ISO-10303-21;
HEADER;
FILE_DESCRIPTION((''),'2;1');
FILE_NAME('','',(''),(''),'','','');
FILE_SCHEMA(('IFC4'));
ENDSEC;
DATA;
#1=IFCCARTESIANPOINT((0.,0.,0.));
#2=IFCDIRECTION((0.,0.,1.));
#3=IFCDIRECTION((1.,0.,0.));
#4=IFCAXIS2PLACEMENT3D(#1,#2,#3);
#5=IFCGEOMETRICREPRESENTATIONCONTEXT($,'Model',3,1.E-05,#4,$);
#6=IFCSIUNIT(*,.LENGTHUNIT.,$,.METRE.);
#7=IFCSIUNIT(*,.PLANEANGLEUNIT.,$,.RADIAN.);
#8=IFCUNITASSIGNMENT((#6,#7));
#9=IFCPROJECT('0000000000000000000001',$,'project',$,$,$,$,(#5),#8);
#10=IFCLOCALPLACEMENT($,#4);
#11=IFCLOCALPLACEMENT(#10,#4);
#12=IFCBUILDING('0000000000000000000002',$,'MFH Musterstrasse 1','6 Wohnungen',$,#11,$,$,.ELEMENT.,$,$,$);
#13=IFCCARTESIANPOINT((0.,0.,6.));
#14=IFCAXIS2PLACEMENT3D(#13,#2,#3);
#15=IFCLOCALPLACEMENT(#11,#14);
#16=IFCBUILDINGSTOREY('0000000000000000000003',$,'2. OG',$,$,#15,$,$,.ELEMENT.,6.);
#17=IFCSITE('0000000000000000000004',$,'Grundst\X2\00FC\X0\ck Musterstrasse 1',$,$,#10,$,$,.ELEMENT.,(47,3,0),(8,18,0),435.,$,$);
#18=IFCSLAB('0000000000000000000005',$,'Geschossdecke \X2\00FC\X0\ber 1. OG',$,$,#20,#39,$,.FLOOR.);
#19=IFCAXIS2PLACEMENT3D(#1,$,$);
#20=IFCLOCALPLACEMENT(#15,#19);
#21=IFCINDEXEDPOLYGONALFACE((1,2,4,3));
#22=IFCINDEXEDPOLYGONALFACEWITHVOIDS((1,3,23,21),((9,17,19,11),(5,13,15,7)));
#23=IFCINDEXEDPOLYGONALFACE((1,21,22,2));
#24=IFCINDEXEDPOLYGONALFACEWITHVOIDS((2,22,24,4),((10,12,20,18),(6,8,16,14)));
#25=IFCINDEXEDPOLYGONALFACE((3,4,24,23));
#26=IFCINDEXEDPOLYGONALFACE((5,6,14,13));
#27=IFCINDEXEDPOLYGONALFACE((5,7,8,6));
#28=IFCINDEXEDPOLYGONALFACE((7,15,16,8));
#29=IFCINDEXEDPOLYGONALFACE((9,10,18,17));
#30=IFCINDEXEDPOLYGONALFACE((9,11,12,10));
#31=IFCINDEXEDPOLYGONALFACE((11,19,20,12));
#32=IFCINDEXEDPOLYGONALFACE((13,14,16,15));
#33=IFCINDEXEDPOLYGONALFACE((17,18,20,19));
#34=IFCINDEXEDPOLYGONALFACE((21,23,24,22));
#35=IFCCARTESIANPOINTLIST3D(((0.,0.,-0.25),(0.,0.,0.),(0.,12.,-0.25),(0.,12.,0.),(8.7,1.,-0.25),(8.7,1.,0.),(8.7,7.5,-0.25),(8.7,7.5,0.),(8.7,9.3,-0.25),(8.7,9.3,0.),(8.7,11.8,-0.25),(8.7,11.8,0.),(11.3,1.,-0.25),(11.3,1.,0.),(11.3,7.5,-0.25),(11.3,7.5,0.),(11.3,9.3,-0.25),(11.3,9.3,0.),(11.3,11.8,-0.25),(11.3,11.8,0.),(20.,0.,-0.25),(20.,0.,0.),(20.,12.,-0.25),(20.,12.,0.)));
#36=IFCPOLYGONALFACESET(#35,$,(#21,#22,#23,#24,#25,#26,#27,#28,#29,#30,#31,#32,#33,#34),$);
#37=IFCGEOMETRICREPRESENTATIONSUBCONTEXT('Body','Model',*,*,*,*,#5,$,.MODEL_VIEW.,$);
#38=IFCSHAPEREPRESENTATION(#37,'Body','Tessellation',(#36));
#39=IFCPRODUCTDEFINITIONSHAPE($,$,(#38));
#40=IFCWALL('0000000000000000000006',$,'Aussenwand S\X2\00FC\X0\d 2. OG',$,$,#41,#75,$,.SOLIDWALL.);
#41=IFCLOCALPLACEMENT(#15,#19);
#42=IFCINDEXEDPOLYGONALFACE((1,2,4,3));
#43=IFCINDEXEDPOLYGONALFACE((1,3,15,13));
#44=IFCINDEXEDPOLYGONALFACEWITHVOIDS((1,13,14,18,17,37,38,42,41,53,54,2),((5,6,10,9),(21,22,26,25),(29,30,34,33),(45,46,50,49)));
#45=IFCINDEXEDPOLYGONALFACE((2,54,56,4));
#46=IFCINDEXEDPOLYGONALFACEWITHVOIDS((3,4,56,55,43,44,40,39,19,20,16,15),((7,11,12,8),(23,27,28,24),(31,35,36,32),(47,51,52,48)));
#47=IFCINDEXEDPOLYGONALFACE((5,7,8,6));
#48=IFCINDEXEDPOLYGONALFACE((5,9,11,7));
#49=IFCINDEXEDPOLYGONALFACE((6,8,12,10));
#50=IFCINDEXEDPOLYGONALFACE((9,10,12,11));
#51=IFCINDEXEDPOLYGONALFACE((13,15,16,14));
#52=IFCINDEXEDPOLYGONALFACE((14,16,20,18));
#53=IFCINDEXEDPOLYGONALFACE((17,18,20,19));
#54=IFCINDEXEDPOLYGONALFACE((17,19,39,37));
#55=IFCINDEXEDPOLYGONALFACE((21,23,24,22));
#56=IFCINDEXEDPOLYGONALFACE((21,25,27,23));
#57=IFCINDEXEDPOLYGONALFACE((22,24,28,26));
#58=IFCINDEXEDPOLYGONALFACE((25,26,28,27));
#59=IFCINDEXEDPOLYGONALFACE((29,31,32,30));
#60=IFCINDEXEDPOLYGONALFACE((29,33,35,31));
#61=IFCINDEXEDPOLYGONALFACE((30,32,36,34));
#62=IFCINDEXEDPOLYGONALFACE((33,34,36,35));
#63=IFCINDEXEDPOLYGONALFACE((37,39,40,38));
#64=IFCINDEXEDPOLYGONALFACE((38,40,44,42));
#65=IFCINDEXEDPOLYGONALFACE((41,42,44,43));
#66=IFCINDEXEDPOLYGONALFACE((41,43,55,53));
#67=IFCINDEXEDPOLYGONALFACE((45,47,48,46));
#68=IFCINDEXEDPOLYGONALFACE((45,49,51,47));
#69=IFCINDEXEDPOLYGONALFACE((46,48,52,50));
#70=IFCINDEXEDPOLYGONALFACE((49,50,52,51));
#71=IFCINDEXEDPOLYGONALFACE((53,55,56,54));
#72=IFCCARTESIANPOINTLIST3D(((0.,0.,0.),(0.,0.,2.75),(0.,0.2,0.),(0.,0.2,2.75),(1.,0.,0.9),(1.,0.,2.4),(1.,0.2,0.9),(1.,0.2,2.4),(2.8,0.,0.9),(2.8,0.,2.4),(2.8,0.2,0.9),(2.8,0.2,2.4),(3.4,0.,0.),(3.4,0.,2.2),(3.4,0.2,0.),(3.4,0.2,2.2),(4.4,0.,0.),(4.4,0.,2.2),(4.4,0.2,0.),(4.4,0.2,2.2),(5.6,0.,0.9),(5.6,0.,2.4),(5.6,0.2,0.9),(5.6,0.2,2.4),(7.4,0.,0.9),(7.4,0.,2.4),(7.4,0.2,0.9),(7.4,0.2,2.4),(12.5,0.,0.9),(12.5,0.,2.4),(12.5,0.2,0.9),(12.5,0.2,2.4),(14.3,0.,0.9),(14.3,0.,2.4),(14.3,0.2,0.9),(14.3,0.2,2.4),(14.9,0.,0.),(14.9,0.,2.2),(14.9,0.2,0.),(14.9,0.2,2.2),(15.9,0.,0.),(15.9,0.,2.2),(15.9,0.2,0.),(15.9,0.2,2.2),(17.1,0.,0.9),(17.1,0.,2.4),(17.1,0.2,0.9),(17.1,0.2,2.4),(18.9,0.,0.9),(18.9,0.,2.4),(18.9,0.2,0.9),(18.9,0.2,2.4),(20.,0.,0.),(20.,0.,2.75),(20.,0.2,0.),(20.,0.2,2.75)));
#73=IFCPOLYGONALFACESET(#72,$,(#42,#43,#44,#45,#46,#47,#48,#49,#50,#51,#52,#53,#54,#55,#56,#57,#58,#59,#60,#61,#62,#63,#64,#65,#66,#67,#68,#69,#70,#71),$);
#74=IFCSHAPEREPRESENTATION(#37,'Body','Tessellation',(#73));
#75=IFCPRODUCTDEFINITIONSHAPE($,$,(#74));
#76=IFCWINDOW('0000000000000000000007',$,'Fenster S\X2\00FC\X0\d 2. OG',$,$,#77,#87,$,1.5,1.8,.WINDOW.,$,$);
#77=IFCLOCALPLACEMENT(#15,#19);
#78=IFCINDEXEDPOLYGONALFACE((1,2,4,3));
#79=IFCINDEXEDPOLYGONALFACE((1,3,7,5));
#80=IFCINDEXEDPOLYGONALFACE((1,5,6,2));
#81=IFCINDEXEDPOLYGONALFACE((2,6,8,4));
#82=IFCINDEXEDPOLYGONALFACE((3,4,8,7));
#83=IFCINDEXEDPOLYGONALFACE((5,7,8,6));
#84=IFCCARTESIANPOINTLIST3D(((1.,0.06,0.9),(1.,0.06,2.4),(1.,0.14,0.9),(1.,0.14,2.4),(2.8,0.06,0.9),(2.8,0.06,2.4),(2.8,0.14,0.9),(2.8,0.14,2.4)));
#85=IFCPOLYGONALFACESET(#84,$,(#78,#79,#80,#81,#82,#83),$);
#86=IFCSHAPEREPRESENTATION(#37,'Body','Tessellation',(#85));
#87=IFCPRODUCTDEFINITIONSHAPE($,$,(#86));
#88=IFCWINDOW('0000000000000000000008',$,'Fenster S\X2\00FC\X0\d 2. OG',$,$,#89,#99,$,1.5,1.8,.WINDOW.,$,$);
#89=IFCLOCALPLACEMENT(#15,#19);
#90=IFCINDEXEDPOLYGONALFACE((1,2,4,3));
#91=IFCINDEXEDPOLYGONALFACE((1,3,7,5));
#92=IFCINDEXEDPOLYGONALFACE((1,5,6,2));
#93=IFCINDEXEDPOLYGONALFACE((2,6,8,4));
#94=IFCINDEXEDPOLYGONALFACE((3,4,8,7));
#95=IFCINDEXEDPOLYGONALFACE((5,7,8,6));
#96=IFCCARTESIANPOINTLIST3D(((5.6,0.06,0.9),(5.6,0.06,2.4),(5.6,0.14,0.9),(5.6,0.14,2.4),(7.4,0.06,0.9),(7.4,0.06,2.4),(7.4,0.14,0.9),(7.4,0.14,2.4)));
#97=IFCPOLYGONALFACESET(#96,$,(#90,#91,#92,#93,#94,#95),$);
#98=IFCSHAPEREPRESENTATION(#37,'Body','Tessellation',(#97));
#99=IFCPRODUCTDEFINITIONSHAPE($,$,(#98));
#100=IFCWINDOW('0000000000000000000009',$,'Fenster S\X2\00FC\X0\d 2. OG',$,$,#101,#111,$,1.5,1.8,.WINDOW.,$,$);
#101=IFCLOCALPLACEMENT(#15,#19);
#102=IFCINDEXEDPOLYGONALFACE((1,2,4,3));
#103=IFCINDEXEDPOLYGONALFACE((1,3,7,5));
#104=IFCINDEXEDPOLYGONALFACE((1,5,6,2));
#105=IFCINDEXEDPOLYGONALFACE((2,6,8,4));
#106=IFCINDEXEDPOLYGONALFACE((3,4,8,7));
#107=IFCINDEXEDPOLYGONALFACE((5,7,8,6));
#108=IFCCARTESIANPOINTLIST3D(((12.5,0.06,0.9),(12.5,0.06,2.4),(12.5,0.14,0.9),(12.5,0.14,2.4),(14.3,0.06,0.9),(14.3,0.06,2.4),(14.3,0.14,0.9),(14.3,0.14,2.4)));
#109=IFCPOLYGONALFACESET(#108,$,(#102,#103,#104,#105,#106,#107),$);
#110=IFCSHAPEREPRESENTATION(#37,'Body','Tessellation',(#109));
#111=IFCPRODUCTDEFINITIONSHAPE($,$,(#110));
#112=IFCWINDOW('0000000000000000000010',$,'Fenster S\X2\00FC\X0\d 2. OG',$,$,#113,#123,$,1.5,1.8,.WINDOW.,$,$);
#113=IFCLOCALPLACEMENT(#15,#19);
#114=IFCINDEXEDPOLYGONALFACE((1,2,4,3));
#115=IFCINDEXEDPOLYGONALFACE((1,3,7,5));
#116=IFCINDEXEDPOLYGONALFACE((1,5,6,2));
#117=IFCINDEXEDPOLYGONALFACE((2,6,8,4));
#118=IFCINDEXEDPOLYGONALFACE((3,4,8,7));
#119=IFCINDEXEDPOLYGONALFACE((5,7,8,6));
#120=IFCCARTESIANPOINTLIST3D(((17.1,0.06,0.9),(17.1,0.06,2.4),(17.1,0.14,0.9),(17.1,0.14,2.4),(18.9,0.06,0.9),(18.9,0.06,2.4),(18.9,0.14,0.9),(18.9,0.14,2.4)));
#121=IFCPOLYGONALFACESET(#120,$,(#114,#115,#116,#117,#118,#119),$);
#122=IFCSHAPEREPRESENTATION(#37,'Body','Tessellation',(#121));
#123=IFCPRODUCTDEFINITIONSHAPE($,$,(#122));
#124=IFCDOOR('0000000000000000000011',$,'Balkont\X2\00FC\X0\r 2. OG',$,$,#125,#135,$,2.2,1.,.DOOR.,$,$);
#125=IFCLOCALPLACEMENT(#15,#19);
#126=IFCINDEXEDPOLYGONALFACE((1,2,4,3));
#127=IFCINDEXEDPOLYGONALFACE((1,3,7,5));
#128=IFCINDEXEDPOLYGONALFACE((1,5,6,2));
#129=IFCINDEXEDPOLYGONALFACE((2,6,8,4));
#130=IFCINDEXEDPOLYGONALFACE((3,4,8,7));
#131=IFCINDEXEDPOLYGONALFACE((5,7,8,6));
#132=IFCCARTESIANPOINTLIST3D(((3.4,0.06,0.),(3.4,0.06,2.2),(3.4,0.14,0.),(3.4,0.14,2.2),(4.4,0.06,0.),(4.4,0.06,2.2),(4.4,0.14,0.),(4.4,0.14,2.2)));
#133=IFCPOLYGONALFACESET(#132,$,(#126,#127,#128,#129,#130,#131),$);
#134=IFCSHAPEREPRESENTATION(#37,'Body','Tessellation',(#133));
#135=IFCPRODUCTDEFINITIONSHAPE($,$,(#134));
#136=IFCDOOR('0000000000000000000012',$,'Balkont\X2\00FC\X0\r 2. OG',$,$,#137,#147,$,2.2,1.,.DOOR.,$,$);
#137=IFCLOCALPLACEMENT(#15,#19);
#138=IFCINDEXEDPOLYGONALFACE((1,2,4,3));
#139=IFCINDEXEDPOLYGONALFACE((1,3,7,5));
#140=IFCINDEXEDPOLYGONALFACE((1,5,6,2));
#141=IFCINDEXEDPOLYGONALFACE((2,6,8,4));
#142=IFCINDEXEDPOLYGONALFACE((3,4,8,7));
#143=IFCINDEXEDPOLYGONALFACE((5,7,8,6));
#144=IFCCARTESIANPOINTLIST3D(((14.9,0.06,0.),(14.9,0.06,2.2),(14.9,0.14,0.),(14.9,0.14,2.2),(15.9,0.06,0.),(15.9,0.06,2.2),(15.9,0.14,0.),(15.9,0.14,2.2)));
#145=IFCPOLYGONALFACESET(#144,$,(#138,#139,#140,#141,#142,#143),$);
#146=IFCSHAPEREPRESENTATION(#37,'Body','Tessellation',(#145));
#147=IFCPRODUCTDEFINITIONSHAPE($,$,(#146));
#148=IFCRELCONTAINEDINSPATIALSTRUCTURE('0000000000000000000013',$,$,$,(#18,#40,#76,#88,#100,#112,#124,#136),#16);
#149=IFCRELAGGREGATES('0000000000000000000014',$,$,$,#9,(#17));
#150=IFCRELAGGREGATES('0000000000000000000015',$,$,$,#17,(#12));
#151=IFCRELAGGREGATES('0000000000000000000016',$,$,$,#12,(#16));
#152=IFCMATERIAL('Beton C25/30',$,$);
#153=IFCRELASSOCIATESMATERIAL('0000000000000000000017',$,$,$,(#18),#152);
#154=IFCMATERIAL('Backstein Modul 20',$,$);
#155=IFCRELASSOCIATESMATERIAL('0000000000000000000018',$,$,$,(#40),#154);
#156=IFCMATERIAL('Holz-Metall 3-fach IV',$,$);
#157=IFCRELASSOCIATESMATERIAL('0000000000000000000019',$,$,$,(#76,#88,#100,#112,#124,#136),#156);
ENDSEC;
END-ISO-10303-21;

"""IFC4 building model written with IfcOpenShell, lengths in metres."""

from ifc_helpers import new_model, si_unit, frame, frame_2d, origin_with_axes, place, context, subcontext, project, spatial, rectangle, extrude, material, element, fill, save


model = new_model("IFC4")

# Units and contexts
model_context = context("Model", 3, precision=1e-05, world=origin_with_axes())
body_context = subcontext(model_context, "Body", "Model", "MODEL_VIEW")
ifc_project = project(units=[si_unit("LENGTHUNIT", "METRE"), si_unit("PLANEANGLEUNIT", "RADIAN")], contexts=[model_context])

# Site, building, storey
site_placement = place(None, origin_with_axes())
site = spatial("IfcSite", under=ifc_project, at=site_placement, Name="Grundstück Musterstrasse 1", CompositionType="ELEMENT", RefLatitude=(47, 3, 0), RefLongitude=(8, 18, 0), RefElevation=435.0)
building_placement = place(site_placement, origin_with_axes())
building = spatial("IfcBuilding", under=site, at=building_placement, Name="MFH Musterstrasse 1", Description="6 Wohnungen", CompositionType="ELEMENT")
storey_placement = place(building_placement, frame((0.0, 0.0, 6.0), z_axis=(0.0, 0.0, 1.0), x_axis=(1.0, 0.0, 0.0)))
storey = spatial("IfcBuildingStorey", under=building, at=storey_placement, Name="2. OG", CompositionType="ELEMENT", Elevation=6.0)

# Slab, openings
ifc_material_1 = material(Name="Beton C25/30")
slab_placement = place(storey_placement, origin_with_axes())
slab = element("IfcSlab", 1, at=slab_placement, inside=storey, material=ifc_material_1, Name="Geschossdecke über 1. OG", PredefinedType="FLOOR", context=body_context, shape_type="SweptSolid", body=[
    extrude(rectangle(XDim=20.0, YDim=12.0, at=frame_2d((10.0, 6.0), x_axis=(1.0, 0.0))), frame((0.0, 0.0, -0.25), z_axis=(0.0, 0.0, 1.0), x_axis=(1.0, 0.0, 0.0)), (0.0, 0.0, 1.0), 0.25),
])
opening_1_placement = place(storey_placement, origin_with_axes())
element("IfcOpeningElement", 2, at=opening_1_placement, cuts=slab, PredefinedType="OPENING", context=body_context, shape_type="SweptSolid", body=[
    extrude(rectangle(XDim=2.6, YDim=6.5, at=frame_2d((1.3, 3.25), x_axis=(1.0, 0.0))), frame((8.7, 1.0, -0.26), z_axis=(0.0, 0.0, 1.0), x_axis=(1.0, 0.0, 0.0)), (0.0, 0.0, 1.0), 0.27),
])
opening_2_placement = place(storey_placement, origin_with_axes())
element("IfcOpeningElement", 3, at=opening_2_placement, cuts=slab, PredefinedType="OPENING", context=body_context, shape_type="SweptSolid", body=[
    extrude(rectangle(XDim=2.6, YDim=2.5, at=frame_2d((1.3, 1.25), x_axis=(1.0, 0.0))), frame((8.7, 9.3, -0.26), z_axis=(0.0, 0.0, 1.0), x_axis=(1.0, 0.0, 0.0)), (0.0, 0.0, 1.0), 0.27),
])

# Wall, openings, windows, doors
ifc_material_2 = material(Name="Backstein Modul 20")
wall_1_placement = place(storey_placement, origin_with_axes())
wall_1 = element("IfcWall", 4, at=wall_1_placement, inside=storey, material=ifc_material_2, Name="Aussenwand Süd 2. OG", PredefinedType="SOLIDWALL", context=body_context, shape_type="SweptSolid", body=[
    extrude(rectangle(XDim=20.0, YDim=0.2, at=frame_2d((10.0, 0.1), x_axis=(1.0, 0.0))), origin_with_axes(), (0.0, 0.0, 1.0), 2.75),
])
opening_3_placement = place(storey_placement, origin_with_axes())
element("IfcOpeningElement", 5, at=opening_3_placement, cuts=wall_1, PredefinedType="OPENING", context=body_context, shape_type="SweptSolid", body=[
    extrude(rectangle(XDim=1.8, YDim=0.3, at=frame_2d((0.9, 0.15), x_axis=(1.0, 0.0))), frame((1.0, -0.05, 0.9), z_axis=(0.0, 0.0, 1.0), x_axis=(1.0, 0.0, 0.0)), (0.0, 0.0, 1.0), 1.5),
])
opening_4_placement = place(storey_placement, origin_with_axes())
element("IfcOpeningElement", 6, at=opening_4_placement, cuts=wall_1, PredefinedType="OPENING", context=body_context, shape_type="SweptSolid", body=[
    extrude(rectangle(XDim=1.8, YDim=0.3, at=frame_2d((0.9, 0.15), x_axis=(1.0, 0.0))), frame((5.6, -0.05, 0.9), z_axis=(0.0, 0.0, 1.0), x_axis=(1.0, 0.0, 0.0)), (0.0, 0.0, 1.0), 1.5),
])
opening_5_placement = place(storey_placement, origin_with_axes())
element("IfcOpeningElement", 7, at=opening_5_placement, cuts=wall_1, PredefinedType="OPENING", context=body_context, shape_type="SweptSolid", body=[
    extrude(rectangle(XDim=1.8, YDim=0.3, at=frame_2d((0.9, 0.15), x_axis=(1.0, 0.0))), frame((12.5, -0.05, 0.9), z_axis=(0.0, 0.0, 1.0), x_axis=(1.0, 0.0, 0.0)), (0.0, 0.0, 1.0), 1.5),
])
opening_6_placement = place(storey_placement, origin_with_axes())
element("IfcOpeningElement", 8, at=opening_6_placement, cuts=wall_1, PredefinedType="OPENING", context=body_context, shape_type="SweptSolid", body=[
    extrude(rectangle(XDim=1.8, YDim=0.3, at=frame_2d((0.9, 0.15), x_axis=(1.0, 0.0))), frame((17.1, -0.05, 0.9), z_axis=(0.0, 0.0, 1.0), x_axis=(1.0, 0.0, 0.0)), (0.0, 0.0, 1.0), 1.5),
])
opening_7_placement = place(storey_placement, origin_with_axes())
element("IfcOpeningElement", 9, at=opening_7_placement, cuts=wall_1, PredefinedType="OPENING", context=body_context, shape_type="SweptSolid", body=[
    extrude(rectangle(XDim=1.0, YDim=0.3, at=frame_2d((0.5, 0.15), x_axis=(1.0, 0.0))), frame((3.4, -0.05, 0.0), z_axis=(0.0, 0.0, 1.0), x_axis=(1.0, 0.0, 0.0)), (0.0, 0.0, 1.0), 2.2),
])
opening_8_placement = place(storey_placement, origin_with_axes())
element("IfcOpeningElement", 10, at=opening_8_placement, cuts=wall_1, PredefinedType="OPENING", context=body_context, shape_type="SweptSolid", body=[
    extrude(rectangle(XDim=1.0, YDim=0.3, at=frame_2d((0.5, 0.15), x_axis=(1.0, 0.0))), frame((14.9, -0.05, 0.0), z_axis=(0.0, 0.0, 1.0), x_axis=(1.0, 0.0, 0.0)), (0.0, 0.0, 1.0), 2.2),
])
opening_9_placement = place(storey_placement, origin_with_axes())
opening_9 = element("IfcOpeningElement", 11, at=opening_9_placement, cuts=wall_1, PredefinedType="OPENING", context=body_context, shape_type="SweptSolid", body=[
    extrude(rectangle(XDim=1.8, YDim=0.22, at=frame_2d((0.9, 0.11), x_axis=(1.0, 0.0))), frame((1.0, -0.01, 0.9), z_axis=(0.0, 0.0, 1.0), x_axis=(1.0, 0.0, 0.0)), (0.0, 0.0, 1.0), 1.5),
])
opening_10_placement = place(storey_placement, origin_with_axes())
opening_10 = element("IfcOpeningElement", 12, at=opening_10_placement, cuts=wall_1, PredefinedType="OPENING", context=body_context, shape_type="SweptSolid", body=[
    extrude(rectangle(XDim=1.8, YDim=0.22, at=frame_2d((0.9, 0.11), x_axis=(1.0, 0.0))), frame((5.6, -0.01, 0.9), z_axis=(0.0, 0.0, 1.0), x_axis=(1.0, 0.0, 0.0)), (0.0, 0.0, 1.0), 1.5),
])
opening_11_placement = place(storey_placement, origin_with_axes())
opening_11 = element("IfcOpeningElement", 13, at=opening_11_placement, cuts=wall_1, PredefinedType="OPENING", context=body_context, shape_type="SweptSolid", body=[
    extrude(rectangle(XDim=1.8, YDim=0.22, at=frame_2d((0.9, 0.11), x_axis=(1.0, 0.0))), frame((12.5, -0.01, 0.9), z_axis=(0.0, 0.0, 1.0), x_axis=(1.0, 0.0, 0.0)), (0.0, 0.0, 1.0), 1.5),
])
opening_12_placement = place(storey_placement, origin_with_axes())
opening_12 = element("IfcOpeningElement", 14, at=opening_12_placement, cuts=wall_1, PredefinedType="OPENING", context=body_context, shape_type="SweptSolid", body=[
    extrude(rectangle(XDim=1.8, YDim=0.22, at=frame_2d((0.9, 0.11), x_axis=(1.0, 0.0))), frame((17.1, -0.01, 0.9), z_axis=(0.0, 0.0, 1.0), x_axis=(1.0, 0.0, 0.0)), (0.0, 0.0, 1.0), 1.5),
])
opening_13_placement = place(storey_placement, origin_with_axes())
opening_13 = element("IfcOpeningElement", 15, at=opening_13_placement, cuts=wall_1, PredefinedType="OPENING", context=body_context, shape_type="SweptSolid", body=[
    extrude(rectangle(XDim=1.0, YDim=0.22, at=frame_2d((0.5, 0.11), x_axis=(1.0, 0.0))), frame((3.4, -0.01, 0.0), z_axis=(0.0, 0.0, 1.0), x_axis=(1.0, 0.0, 0.0)), (0.0, 0.0, 1.0), 2.2),
])
opening_14_placement = place(storey_placement, origin_with_axes())
opening_14 = element("IfcOpeningElement", 16, at=opening_14_placement, cuts=wall_1, PredefinedType="OPENING", context=body_context, shape_type="SweptSolid", body=[
    extrude(rectangle(XDim=1.0, YDim=0.22, at=frame_2d((0.5, 0.11), x_axis=(1.0, 0.0))), frame((14.9, -0.01, 0.0), z_axis=(0.0, 0.0, 1.0), x_axis=(1.0, 0.0, 0.0)), (0.0, 0.0, 1.0), 2.2),
])
ifc_material_3 = material(Name="Holz-Metall 3-fach IV")
window_1_placement = place(storey_placement, origin_with_axes())
window_1 = element("IfcWindow", 17, at=window_1_placement, inside=storey, material=ifc_material_3, Name="Fenster Süd 2. OG", OverallHeight=1.5, OverallWidth=1.8, PredefinedType="WINDOW", context=body_context, shape_type="SweptSolid", body=[
    extrude(rectangle(XDim=1.8, YDim=0.08, at=frame_2d((0.9, 0.04), x_axis=(1.0, 0.0))), frame((1.0, 0.06, 0.9), z_axis=(0.0, 0.0, 1.0), x_axis=(1.0, 0.0, 0.0)), (0.0, 0.0, 1.0), 1.5),
])
fill(opening_9, window_1)
window_2_placement = place(storey_placement, origin_with_axes())
window_2 = element("IfcWindow", 18, at=window_2_placement, inside=storey, material=ifc_material_3, Name="Fenster Süd 2. OG", OverallHeight=1.5, OverallWidth=1.8, PredefinedType="WINDOW", context=body_context, shape_type="SweptSolid", body=[
    extrude(rectangle(XDim=1.8, YDim=0.08, at=frame_2d((0.9, 0.04), x_axis=(1.0, 0.0))), frame((5.6, 0.06, 0.9), z_axis=(0.0, 0.0, 1.0), x_axis=(1.0, 0.0, 0.0)), (0.0, 0.0, 1.0), 1.5),
])
fill(opening_10, window_2)
window_3_placement = place(storey_placement, origin_with_axes())
window_3 = element("IfcWindow", 19, at=window_3_placement, inside=storey, material=ifc_material_3, Name="Fenster Süd 2. OG", OverallHeight=1.5, OverallWidth=1.8, PredefinedType="WINDOW", context=body_context, shape_type="SweptSolid", body=[
    extrude(rectangle(XDim=1.8, YDim=0.08, at=frame_2d((0.9, 0.04), x_axis=(1.0, 0.0))), frame((12.5, 0.06, 0.9), z_axis=(0.0, 0.0, 1.0), x_axis=(1.0, 0.0, 0.0)), (0.0, 0.0, 1.0), 1.5),
])
fill(opening_11, window_3)
window_4_placement = place(storey_placement, origin_with_axes())
window_4 = element("IfcWindow", 20, at=window_4_placement, inside=storey, material=ifc_material_3, Name="Fenster Süd 2. OG", OverallHeight=1.5, OverallWidth=1.8, PredefinedType="WINDOW", context=body_context, shape_type="SweptSolid", body=[
    extrude(rectangle(XDim=1.8, YDim=0.08, at=frame_2d((0.9, 0.04), x_axis=(1.0, 0.0))), frame((17.1, 0.06, 0.9), z_axis=(0.0, 0.0, 1.0), x_axis=(1.0, 0.0, 0.0)), (0.0, 0.0, 1.0), 1.5),
])
fill(opening_12, window_4)
door_1_placement = place(storey_placement, origin_with_axes())
door_1 = element("IfcDoor", 21, at=door_1_placement, inside=storey, material=ifc_material_3, Name="Balkontür 2. OG", OverallHeight=2.2, OverallWidth=1.0, PredefinedType="DOOR", context=body_context, shape_type="SweptSolid", body=[
    extrude(rectangle(XDim=1.0, YDim=0.08, at=frame_2d((0.5, 0.04), x_axis=(1.0, 0.0))), frame((3.4, 0.06, 0.0), z_axis=(0.0, 0.0, 1.0), x_axis=(1.0, 0.0, 0.0)), (0.0, 0.0, 1.0), 2.2),
])
fill(opening_13, door_1)
door_2_placement = place(storey_placement, origin_with_axes())
door_2 = element("IfcDoor", 22, at=door_2_placement, inside=storey, material=ifc_material_3, Name="Balkontür 2. OG", OverallHeight=2.2, OverallWidth=1.0, PredefinedType="DOOR", context=body_context, shape_type="SweptSolid", body=[
    extrude(rectangle(XDim=1.0, YDim=0.08, at=frame_2d((0.5, 0.04), x_axis=(1.0, 0.0))), frame((14.9, 0.06, 0.0), z_axis=(0.0, 0.0, 1.0), x_axis=(1.0, 0.0, 0.0)), (0.0, 0.0, 1.0), 2.2),
])
fill(opening_14, door_2)

save(model, "model.ifc")
